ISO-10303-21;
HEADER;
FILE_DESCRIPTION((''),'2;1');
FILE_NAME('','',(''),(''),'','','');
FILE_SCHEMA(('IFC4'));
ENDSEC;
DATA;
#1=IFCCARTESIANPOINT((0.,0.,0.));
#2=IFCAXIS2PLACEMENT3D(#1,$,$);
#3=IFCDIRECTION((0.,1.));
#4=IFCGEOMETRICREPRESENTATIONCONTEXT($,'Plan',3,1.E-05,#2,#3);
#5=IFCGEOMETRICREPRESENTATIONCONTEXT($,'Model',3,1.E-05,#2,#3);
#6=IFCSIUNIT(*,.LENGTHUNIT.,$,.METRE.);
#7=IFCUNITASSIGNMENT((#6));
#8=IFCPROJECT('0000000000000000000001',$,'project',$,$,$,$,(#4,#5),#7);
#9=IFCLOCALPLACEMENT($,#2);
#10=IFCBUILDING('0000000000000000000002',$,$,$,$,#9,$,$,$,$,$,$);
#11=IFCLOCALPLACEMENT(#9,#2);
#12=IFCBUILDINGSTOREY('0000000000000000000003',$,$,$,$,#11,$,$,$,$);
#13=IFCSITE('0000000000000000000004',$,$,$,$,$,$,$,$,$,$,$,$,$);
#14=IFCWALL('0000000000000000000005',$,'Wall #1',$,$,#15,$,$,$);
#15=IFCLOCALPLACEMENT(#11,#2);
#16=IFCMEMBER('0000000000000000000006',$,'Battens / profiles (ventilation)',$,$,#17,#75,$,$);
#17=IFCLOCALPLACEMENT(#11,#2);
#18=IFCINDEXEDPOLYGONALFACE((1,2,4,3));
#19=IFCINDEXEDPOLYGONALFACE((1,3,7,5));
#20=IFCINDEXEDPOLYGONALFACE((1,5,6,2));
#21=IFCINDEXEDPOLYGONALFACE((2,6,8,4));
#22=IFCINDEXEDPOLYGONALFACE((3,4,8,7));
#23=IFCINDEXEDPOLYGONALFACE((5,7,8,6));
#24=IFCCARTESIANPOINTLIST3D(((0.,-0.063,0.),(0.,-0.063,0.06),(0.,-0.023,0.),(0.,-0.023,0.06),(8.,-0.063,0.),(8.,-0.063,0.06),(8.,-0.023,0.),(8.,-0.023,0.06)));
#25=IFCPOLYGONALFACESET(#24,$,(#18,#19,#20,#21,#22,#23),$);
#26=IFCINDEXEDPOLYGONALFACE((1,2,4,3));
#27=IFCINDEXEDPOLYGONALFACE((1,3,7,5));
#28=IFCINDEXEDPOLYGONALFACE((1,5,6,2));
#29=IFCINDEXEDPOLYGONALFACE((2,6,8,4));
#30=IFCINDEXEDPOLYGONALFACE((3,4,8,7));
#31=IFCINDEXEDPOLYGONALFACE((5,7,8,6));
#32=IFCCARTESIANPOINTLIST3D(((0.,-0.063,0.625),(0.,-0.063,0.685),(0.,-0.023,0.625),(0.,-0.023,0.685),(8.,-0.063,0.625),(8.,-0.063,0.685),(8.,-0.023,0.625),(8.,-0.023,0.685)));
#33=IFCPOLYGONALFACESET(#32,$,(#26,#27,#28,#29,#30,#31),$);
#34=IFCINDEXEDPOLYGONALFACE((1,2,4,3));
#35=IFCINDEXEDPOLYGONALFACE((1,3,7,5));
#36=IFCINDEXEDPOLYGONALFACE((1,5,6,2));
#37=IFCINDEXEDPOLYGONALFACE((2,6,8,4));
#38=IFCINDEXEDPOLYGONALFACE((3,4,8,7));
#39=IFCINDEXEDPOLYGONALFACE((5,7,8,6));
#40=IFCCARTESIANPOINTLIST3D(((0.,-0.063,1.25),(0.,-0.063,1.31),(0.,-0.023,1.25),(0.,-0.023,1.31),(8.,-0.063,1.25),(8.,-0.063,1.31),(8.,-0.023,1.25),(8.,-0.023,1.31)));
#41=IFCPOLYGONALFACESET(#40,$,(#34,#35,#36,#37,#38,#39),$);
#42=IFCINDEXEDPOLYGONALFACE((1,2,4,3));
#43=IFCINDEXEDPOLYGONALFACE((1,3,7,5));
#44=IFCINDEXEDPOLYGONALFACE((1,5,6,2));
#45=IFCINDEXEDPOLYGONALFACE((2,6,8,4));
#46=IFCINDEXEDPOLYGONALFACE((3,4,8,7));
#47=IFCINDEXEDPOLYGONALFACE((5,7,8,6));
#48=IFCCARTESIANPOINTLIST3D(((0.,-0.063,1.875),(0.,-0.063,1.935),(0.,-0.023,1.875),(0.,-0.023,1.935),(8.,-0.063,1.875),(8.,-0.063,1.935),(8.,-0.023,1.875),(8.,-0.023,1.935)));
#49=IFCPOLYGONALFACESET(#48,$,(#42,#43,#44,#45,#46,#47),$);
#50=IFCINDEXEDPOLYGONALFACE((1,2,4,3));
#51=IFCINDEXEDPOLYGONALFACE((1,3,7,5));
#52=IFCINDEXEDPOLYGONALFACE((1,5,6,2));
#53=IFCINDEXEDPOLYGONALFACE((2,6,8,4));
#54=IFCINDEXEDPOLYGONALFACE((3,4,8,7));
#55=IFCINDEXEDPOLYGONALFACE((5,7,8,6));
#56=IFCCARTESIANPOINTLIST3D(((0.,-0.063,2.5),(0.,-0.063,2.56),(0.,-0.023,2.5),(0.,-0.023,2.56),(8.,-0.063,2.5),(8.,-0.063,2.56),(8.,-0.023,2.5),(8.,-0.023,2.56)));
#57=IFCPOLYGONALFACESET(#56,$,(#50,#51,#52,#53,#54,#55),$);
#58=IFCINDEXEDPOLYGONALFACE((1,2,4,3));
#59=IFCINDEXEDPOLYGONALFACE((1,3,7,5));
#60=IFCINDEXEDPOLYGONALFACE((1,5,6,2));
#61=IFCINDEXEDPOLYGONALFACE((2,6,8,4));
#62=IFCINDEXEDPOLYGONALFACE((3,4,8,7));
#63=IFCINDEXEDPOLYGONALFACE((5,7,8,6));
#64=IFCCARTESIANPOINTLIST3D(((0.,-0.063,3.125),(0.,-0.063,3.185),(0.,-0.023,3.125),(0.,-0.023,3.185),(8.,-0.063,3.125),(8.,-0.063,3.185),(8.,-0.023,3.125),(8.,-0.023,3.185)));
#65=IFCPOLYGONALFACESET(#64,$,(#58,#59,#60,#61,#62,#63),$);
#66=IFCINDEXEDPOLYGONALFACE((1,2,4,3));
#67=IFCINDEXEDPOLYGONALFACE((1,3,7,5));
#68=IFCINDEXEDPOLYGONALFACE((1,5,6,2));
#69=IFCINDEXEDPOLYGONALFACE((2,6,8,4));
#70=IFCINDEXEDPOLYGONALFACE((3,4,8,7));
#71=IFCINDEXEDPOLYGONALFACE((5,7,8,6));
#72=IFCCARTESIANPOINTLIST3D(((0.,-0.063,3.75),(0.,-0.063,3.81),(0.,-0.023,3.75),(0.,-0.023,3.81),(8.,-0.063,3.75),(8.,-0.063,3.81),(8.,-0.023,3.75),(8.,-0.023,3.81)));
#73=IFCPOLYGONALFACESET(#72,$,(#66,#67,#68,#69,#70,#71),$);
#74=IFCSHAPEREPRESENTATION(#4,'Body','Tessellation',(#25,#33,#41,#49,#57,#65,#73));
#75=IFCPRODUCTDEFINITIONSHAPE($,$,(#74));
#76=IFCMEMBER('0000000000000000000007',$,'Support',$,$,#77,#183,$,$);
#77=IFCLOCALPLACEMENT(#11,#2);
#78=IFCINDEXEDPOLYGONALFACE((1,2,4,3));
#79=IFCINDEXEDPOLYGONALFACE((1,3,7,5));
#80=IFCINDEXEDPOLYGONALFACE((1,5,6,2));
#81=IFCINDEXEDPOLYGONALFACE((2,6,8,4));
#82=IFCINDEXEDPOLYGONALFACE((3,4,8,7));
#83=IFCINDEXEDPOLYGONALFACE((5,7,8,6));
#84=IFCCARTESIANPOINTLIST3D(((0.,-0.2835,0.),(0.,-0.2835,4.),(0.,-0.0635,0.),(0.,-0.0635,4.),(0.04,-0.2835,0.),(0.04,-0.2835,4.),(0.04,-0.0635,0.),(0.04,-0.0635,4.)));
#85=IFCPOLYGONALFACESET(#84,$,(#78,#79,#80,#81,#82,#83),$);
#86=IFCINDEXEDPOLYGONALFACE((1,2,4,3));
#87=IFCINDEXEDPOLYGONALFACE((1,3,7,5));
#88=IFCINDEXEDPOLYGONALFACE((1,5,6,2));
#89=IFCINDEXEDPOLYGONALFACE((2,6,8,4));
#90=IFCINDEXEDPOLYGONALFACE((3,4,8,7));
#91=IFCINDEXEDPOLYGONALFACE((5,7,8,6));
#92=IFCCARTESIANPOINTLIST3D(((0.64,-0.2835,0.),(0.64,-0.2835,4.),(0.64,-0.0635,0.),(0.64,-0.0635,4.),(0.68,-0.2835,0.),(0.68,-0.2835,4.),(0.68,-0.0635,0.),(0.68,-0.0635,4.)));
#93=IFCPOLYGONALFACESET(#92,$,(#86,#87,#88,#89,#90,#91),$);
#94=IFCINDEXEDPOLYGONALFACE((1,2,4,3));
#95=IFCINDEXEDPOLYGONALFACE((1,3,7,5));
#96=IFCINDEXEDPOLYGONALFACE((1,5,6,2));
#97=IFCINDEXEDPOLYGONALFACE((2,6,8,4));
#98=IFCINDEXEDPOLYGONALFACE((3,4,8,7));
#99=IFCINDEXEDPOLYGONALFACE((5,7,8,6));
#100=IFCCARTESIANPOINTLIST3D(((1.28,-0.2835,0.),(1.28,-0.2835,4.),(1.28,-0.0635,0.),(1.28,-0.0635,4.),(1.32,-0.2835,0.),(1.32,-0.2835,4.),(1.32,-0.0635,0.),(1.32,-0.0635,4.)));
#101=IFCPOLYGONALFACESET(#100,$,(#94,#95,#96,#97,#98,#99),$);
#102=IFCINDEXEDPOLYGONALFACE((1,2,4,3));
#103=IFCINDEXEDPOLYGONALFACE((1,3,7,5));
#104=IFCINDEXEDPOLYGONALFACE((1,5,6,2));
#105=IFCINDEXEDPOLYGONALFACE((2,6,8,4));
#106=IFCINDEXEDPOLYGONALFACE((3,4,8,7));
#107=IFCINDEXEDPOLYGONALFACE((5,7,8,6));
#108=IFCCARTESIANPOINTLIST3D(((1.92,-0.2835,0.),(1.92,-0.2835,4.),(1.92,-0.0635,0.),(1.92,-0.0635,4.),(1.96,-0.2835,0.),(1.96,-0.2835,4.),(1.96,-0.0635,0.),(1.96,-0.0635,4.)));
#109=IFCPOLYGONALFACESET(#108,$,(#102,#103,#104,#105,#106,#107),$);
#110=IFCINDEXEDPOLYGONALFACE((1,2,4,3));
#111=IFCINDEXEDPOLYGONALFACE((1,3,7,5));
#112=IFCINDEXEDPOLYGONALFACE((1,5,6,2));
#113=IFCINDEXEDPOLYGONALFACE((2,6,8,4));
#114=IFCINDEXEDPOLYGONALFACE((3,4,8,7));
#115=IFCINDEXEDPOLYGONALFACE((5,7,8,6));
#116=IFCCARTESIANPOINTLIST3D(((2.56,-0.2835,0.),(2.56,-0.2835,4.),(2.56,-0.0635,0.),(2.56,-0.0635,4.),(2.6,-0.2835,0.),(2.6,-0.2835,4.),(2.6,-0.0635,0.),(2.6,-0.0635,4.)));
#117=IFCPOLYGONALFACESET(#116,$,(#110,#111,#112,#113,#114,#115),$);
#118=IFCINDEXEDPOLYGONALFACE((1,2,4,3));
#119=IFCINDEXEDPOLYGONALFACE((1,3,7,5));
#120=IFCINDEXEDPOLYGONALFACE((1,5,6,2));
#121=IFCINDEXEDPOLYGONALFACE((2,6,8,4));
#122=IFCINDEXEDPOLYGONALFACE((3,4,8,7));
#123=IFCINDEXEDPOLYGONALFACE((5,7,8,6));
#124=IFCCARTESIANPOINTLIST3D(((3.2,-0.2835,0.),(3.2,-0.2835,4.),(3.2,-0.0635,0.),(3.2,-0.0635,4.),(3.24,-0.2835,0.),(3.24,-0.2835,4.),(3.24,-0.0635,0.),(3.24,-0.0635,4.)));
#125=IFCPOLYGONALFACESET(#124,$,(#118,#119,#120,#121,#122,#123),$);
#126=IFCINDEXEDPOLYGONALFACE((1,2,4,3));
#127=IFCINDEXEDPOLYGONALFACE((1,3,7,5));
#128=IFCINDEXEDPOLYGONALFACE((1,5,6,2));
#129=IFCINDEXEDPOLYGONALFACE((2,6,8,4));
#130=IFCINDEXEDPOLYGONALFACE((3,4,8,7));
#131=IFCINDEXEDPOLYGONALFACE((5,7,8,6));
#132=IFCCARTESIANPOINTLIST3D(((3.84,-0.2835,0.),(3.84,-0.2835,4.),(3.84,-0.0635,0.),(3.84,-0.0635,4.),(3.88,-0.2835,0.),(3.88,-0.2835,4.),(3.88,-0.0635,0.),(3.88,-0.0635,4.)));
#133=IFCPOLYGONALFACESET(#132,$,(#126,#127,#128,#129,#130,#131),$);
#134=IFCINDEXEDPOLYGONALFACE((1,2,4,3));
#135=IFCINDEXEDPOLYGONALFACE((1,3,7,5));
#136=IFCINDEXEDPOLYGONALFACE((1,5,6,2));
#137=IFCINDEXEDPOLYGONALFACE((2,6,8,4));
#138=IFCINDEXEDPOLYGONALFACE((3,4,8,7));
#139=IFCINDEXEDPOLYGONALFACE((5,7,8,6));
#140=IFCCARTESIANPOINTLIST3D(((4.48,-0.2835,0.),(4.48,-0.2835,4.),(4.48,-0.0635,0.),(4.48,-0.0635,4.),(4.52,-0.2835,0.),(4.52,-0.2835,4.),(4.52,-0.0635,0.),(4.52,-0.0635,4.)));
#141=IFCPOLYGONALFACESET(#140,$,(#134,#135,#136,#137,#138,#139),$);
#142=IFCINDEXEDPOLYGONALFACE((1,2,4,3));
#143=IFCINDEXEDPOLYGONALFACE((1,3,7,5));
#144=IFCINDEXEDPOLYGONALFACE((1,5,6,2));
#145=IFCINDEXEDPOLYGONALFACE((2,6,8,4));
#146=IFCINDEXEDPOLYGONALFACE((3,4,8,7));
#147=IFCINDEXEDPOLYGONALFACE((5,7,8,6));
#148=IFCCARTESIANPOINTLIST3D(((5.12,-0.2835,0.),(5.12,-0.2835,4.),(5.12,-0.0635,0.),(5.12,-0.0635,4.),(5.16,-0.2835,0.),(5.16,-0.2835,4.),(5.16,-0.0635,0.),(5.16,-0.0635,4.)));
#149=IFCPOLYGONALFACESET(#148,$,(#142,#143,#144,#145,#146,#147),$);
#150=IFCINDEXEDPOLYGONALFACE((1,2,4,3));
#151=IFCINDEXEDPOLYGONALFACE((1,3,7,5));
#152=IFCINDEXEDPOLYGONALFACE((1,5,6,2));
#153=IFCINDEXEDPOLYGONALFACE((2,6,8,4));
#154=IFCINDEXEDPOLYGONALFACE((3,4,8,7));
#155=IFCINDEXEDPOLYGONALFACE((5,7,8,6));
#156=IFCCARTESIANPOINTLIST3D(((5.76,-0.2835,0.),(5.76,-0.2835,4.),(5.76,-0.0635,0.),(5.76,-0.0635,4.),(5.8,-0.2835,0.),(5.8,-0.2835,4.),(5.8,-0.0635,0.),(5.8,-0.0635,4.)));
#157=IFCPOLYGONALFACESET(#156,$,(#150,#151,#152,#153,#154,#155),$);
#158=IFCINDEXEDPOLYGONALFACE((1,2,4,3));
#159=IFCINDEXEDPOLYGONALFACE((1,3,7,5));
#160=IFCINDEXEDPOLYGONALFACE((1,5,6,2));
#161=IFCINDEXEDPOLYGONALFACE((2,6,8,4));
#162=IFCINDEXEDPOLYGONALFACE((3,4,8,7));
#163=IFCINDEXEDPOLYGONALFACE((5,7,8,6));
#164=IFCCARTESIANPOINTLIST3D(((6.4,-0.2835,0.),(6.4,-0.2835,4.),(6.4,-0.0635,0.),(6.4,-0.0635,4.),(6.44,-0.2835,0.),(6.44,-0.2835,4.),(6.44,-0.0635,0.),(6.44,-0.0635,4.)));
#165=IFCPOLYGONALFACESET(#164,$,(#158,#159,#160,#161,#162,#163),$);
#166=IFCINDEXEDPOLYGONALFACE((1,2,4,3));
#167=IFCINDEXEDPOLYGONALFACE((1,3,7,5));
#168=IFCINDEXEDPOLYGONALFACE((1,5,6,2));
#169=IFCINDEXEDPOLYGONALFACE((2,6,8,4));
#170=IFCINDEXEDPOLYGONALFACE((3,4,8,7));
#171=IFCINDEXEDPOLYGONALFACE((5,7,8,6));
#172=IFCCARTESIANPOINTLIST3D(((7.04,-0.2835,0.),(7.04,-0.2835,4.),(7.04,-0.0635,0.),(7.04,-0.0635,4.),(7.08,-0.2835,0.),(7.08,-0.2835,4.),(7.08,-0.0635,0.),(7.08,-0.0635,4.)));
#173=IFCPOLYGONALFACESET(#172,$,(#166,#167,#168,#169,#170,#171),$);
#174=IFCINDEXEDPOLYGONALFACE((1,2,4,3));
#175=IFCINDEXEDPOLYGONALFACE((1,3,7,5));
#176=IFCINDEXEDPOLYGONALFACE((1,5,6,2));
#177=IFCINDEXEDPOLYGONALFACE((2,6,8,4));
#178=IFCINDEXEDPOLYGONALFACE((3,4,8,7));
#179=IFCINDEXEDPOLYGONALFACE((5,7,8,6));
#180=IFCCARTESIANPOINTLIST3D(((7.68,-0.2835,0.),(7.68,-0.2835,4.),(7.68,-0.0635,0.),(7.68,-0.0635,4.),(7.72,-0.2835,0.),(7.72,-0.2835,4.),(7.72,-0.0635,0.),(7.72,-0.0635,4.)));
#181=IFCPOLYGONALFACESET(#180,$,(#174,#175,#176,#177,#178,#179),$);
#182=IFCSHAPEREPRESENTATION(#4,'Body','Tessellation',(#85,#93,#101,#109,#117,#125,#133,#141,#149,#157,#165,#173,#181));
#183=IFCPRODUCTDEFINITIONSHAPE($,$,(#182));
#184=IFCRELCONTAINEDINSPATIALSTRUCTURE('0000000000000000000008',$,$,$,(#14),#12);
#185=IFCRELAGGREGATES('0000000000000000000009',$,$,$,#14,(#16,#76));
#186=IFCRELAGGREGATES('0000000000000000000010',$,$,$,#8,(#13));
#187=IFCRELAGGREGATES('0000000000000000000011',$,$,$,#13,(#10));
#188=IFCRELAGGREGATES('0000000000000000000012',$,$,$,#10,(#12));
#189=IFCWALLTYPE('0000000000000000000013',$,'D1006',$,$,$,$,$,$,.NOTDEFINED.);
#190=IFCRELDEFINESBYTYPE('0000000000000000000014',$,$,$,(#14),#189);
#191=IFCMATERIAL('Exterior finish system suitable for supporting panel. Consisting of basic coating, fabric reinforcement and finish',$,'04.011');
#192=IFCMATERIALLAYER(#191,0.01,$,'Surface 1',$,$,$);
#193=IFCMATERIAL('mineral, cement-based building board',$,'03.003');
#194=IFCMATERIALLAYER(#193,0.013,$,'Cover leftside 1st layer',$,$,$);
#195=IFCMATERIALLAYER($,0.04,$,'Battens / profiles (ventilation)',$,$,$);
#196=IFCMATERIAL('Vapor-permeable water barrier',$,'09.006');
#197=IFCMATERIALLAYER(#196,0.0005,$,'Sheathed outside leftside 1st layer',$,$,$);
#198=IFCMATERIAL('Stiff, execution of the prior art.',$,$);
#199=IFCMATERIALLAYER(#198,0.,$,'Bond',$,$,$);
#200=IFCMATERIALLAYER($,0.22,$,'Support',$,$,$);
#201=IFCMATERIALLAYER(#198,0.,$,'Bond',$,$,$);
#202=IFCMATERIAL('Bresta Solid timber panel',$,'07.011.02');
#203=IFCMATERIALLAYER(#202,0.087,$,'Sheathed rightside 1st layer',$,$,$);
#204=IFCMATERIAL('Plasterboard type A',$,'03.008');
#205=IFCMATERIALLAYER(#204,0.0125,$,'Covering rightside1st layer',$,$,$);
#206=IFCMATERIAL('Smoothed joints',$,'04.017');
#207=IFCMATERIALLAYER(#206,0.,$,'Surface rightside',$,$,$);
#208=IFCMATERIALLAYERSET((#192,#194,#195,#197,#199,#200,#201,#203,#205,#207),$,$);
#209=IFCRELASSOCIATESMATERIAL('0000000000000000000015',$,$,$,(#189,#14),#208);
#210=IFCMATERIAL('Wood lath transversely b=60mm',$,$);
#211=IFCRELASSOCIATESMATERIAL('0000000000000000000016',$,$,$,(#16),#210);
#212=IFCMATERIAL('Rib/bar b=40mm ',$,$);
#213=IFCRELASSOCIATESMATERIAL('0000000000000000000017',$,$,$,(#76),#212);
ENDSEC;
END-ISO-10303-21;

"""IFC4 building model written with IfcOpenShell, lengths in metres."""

from ifc_helpers import new_model, si_unit, direction, frame, frame_2d, origin, place, context, project, spatial, rectangle, extrude, material, layer, layer_set, type_object, element, aggregate, save


model = new_model("IFC4")

# Units and contexts
plan_context = context("Plan", 3, precision=1e-05, world=origin(), true_north=direction((0.0, 1.0)))
model_context = context("Model", 3, precision=1e-05, world=origin(), true_north=direction((0.0, 1.0)))
ifc_project = project(units=[si_unit("LENGTHUNIT", "METRE")], contexts=[plan_context, model_context])

# Site, building, storey
site = spatial("IfcSite", under=ifc_project)
building_placement = place(None, origin())
building = spatial("IfcBuilding", under=site, at=building_placement)
storey_placement = place(building_placement, origin())
storey = spatial("IfcBuildingStorey", under=building, at=storey_placement)

# Wall, members
ifc_material_1 = material(Name="Exterior finish system suitable for supporting panel. Consisting of basic coating, fabric reinforcement and finish", Category="04.011")
ifc_layer_1 = layer(ifc_material_1, 0.01, Name="Surface 1")
ifc_material_2 = material(Name="mineral, cement-based building board", Category="03.003")
ifc_layer_2 = layer(ifc_material_2, 0.013, Name="Cover leftside 1st layer")
ifc_layer_3 = layer(None, 0.04, Name="Battens / profiles (ventilation)")
ifc_material_3 = material(Name="Vapor-permeable water barrier", Category="09.006")
ifc_layer_4 = layer(ifc_material_3, 0.0005, Name="Sheathed outside leftside 1st layer")
ifc_material_4 = material(Name="Stiff, execution of the prior art.")
ifc_layer_5 = layer(ifc_material_4, 0.0, Name="Bond")
ifc_layer_6 = layer(None, 0.22, Name="Support")
ifc_layer_7 = layer(ifc_material_4, 0.0, Name="Bond")
ifc_material_5 = material(Name="Bresta Solid timber panel", Category="07.011.02")
ifc_layer_8 = layer(ifc_material_5, 0.087, Name="Sheathed rightside 1st layer")
ifc_material_6 = material(Name="Plasterboard type A", Category="03.008")
ifc_layer_9 = layer(ifc_material_6, 0.0125, Name="Covering rightside1st layer")
ifc_material_7 = material(Name="Smoothed joints", Category="04.017")
ifc_layer_10 = layer(ifc_material_7, 0.0, Name="Surface rightside")
ifc_layer_set = layer_set([ifc_layer_1, ifc_layer_2, ifc_layer_3, ifc_layer_4, ifc_layer_5, ifc_layer_6, ifc_layer_7, ifc_layer_8, ifc_layer_9, ifc_layer_10])
wall_type = type_object("IfcWallType", Name="D1006", PredefinedType="NOTDEFINED", material=ifc_layer_set)
wall_placement = place(None, frame((0.0, 0.0, 0.0), z_axis=(0.0, -1.0, 0.0), x_axis=(1.0, 0.0, 0.0)))
wall = element("IfcWall", 1, at=wall_placement, inside=storey, type_object=wall_type, material=ifc_layer_set, Name="Wall #1")
ifc_material_8 = material(Name="Wood lath transversely b=60mm")
member_1_placement = place(wall_placement, origin())
member_1 = element("IfcMember", 2, at=member_1_placement, material=ifc_material_8, Name="Battens / profiles (ventilation)", context=plan_context, shape_type="SweptSolid", body=[
    extrude(rectangle(XDim=0.06, YDim=0.04, at=frame_2d((0.03, 0.02), x_axis=(1.0, 0.0))), frame((0.0, 0.0, 0.023), z_axis=(1.0, 0.0, 0.0), x_axis=(0.0, 1.0, 0.0)), (0.0, 0.0, 1.0), 8.0),
    extrude(rectangle(XDim=0.06, YDim=0.04, at=frame_2d((0.03, 0.02), x_axis=(1.0, 0.0))), frame((0.0, 0.625, 0.023), z_axis=(1.0, 0.0, 0.0), x_axis=(0.0, 1.0, 0.0)), (0.0, 0.0, 1.0), 8.0),
    extrude(rectangle(XDim=0.06, YDim=0.04, at=frame_2d((0.03, 0.02), x_axis=(1.0, 0.0))), frame((0.0, 1.25, 0.023), z_axis=(1.0, 0.0, 0.0), x_axis=(0.0, 1.0, 0.0)), (0.0, 0.0, 1.0), 8.0),
    extrude(rectangle(XDim=0.06, YDim=0.04, at=frame_2d((0.03, 0.02), x_axis=(1.0, 0.0))), frame((0.0, 1.875, 0.023), z_axis=(1.0, 0.0, 0.0), x_axis=(0.0, 1.0, 0.0)), (0.0, 0.0, 1.0), 8.0),
    extrude(rectangle(XDim=0.06, YDim=0.04, at=frame_2d((0.03, 0.02), x_axis=(1.0, 0.0))), frame((0.0, 2.5, 0.023), z_axis=(1.0, 0.0, 0.0), x_axis=(0.0, 1.0, 0.0)), (0.0, 0.0, 1.0), 8.0),
    extrude(rectangle(XDim=0.06, YDim=0.04, at=frame_2d((0.03, 0.02), x_axis=(1.0, 0.0))), frame((0.0, 3.125, 0.023), z_axis=(1.0, 0.0, 0.0), x_axis=(0.0, 1.0, 0.0)), (0.0, 0.0, 1.0), 8.0),
    extrude(rectangle(XDim=0.06, YDim=0.04, at=frame_2d((0.03, 0.02), x_axis=(1.0, 0.0))), frame((0.0, 3.75, 0.023), z_axis=(1.0, 0.0, 0.0), x_axis=(0.0, 1.0, 0.0)), (0.0, 0.0, 1.0), 8.0),
])
ifc_material_9 = material(Name="Rib/bar b=40mm ")
member_2_placement = place(wall_placement, origin())
member_2 = element("IfcMember", 3, at=member_2_placement, material=ifc_material_9, Name="Support", context=plan_context, shape_type="SweptSolid", body=[
    extrude(rectangle(XDim=0.04, YDim=0.22, at=frame_2d((0.02, 0.11), x_axis=(1.0, 0.0))), frame((0.0, 4.0, 0.0635), z_axis=(0.0, -1.0, 0.0), x_axis=(1.0, 0.0, 0.0)), (0.0, 0.0, 1.0), 4.0),
    extrude(rectangle(XDim=0.04, YDim=0.22, at=frame_2d((0.02, 0.11), x_axis=(1.0, 0.0))), frame((0.64, 4.0, 0.0635), z_axis=(0.0, -1.0, 0.0), x_axis=(1.0, 0.0, 0.0)), (0.0, 0.0, 1.0), 4.0),
    extrude(rectangle(XDim=0.04, YDim=0.22, at=frame_2d((0.02, 0.11), x_axis=(1.0, 0.0))), frame((1.28, 4.0, 0.0635), z_axis=(0.0, -1.0, 0.0), x_axis=(1.0, 0.0, 0.0)), (0.0, 0.0, 1.0), 4.0),
    extrude(rectangle(XDim=0.04, YDim=0.22, at=frame_2d((0.02, 0.11), x_axis=(1.0, 0.0))), frame((1.92, 4.0, 0.0635), z_axis=(0.0, -1.0, 0.0), x_axis=(1.0, 0.0, 0.0)), (0.0, 0.0, 1.0), 4.0),
    extrude(rectangle(XDim=0.04, YDim=0.22, at=frame_2d((0.02, 0.11), x_axis=(1.0, 0.0))), frame((2.56, 4.0, 0.0635), z_axis=(0.0, -1.0, 0.0), x_axis=(1.0, 0.0, 0.0)), (0.0, 0.0, 1.0), 4.0),
    extrude(rectangle(XDim=0.04, YDim=0.22, at=frame_2d((0.02, 0.11), x_axis=(1.0, 0.0))), frame((3.2, 4.0, 0.0635), z_axis=(0.0, -1.0, 0.0), x_axis=(1.0, 0.0, 0.0)), (0.0, 0.0, 1.0), 4.0),
    extrude(rectangle(XDim=0.04, YDim=0.22, at=frame_2d((0.02, 0.11), x_axis=(1.0, 0.0))), frame((3.84, 4.0, 0.0635), z_axis=(0.0, -1.0, 0.0), x_axis=(1.0, 0.0, 0.0)), (0.0, 0.0, 1.0), 4.0),
    extrude(rectangle(XDim=0.04, YDim=0.22, at=frame_2d((0.02, 0.11), x_axis=(1.0, 0.0))), frame((4.48, 4.0, 0.0635), z_axis=(0.0, -1.0, 0.0), x_axis=(1.0, 0.0, 0.0)), (0.0, 0.0, 1.0), 4.0),
    extrude(rectangle(XDim=0.04, YDim=0.22, at=frame_2d((0.02, 0.11), x_axis=(1.0, 0.0))), frame((5.12, 4.0, 0.0635), z_axis=(0.0, -1.0, 0.0), x_axis=(1.0, 0.0, 0.0)), (0.0, 0.0, 1.0), 4.0),
    extrude(rectangle(XDim=0.04, YDim=0.22, at=frame_2d((0.02, 0.11), x_axis=(1.0, 0.0))), frame((5.76, 4.0, 0.0635), z_axis=(0.0, -1.0, 0.0), x_axis=(1.0, 0.0, 0.0)), (0.0, 0.0, 1.0), 4.0),
    extrude(rectangle(XDim=0.04, YDim=0.22, at=frame_2d((0.02, 0.11), x_axis=(1.0, 0.0))), frame((6.4, 4.0, 0.0635), z_axis=(0.0, -1.0, 0.0), x_axis=(1.0, 0.0, 0.0)), (0.0, 0.0, 1.0), 4.0),
    extrude(rectangle(XDim=0.04, YDim=0.22, at=frame_2d((0.02, 0.11), x_axis=(1.0, 0.0))), frame((7.04, 4.0, 0.0635), z_axis=(0.0, -1.0, 0.0), x_axis=(1.0, 0.0, 0.0)), (0.0, 0.0, 1.0), 4.0),
    extrude(rectangle(XDim=0.04, YDim=0.22, at=frame_2d((0.02, 0.11), x_axis=(1.0, 0.0))), frame((7.68, 4.0, 0.0635), z_axis=(0.0, -1.0, 0.0), x_axis=(1.0, 0.0, 0.0)), (0.0, 0.0, 1.0), 4.0),
])
aggregate(wall, [member_1, member_2])

save(model, "model.ifc")
